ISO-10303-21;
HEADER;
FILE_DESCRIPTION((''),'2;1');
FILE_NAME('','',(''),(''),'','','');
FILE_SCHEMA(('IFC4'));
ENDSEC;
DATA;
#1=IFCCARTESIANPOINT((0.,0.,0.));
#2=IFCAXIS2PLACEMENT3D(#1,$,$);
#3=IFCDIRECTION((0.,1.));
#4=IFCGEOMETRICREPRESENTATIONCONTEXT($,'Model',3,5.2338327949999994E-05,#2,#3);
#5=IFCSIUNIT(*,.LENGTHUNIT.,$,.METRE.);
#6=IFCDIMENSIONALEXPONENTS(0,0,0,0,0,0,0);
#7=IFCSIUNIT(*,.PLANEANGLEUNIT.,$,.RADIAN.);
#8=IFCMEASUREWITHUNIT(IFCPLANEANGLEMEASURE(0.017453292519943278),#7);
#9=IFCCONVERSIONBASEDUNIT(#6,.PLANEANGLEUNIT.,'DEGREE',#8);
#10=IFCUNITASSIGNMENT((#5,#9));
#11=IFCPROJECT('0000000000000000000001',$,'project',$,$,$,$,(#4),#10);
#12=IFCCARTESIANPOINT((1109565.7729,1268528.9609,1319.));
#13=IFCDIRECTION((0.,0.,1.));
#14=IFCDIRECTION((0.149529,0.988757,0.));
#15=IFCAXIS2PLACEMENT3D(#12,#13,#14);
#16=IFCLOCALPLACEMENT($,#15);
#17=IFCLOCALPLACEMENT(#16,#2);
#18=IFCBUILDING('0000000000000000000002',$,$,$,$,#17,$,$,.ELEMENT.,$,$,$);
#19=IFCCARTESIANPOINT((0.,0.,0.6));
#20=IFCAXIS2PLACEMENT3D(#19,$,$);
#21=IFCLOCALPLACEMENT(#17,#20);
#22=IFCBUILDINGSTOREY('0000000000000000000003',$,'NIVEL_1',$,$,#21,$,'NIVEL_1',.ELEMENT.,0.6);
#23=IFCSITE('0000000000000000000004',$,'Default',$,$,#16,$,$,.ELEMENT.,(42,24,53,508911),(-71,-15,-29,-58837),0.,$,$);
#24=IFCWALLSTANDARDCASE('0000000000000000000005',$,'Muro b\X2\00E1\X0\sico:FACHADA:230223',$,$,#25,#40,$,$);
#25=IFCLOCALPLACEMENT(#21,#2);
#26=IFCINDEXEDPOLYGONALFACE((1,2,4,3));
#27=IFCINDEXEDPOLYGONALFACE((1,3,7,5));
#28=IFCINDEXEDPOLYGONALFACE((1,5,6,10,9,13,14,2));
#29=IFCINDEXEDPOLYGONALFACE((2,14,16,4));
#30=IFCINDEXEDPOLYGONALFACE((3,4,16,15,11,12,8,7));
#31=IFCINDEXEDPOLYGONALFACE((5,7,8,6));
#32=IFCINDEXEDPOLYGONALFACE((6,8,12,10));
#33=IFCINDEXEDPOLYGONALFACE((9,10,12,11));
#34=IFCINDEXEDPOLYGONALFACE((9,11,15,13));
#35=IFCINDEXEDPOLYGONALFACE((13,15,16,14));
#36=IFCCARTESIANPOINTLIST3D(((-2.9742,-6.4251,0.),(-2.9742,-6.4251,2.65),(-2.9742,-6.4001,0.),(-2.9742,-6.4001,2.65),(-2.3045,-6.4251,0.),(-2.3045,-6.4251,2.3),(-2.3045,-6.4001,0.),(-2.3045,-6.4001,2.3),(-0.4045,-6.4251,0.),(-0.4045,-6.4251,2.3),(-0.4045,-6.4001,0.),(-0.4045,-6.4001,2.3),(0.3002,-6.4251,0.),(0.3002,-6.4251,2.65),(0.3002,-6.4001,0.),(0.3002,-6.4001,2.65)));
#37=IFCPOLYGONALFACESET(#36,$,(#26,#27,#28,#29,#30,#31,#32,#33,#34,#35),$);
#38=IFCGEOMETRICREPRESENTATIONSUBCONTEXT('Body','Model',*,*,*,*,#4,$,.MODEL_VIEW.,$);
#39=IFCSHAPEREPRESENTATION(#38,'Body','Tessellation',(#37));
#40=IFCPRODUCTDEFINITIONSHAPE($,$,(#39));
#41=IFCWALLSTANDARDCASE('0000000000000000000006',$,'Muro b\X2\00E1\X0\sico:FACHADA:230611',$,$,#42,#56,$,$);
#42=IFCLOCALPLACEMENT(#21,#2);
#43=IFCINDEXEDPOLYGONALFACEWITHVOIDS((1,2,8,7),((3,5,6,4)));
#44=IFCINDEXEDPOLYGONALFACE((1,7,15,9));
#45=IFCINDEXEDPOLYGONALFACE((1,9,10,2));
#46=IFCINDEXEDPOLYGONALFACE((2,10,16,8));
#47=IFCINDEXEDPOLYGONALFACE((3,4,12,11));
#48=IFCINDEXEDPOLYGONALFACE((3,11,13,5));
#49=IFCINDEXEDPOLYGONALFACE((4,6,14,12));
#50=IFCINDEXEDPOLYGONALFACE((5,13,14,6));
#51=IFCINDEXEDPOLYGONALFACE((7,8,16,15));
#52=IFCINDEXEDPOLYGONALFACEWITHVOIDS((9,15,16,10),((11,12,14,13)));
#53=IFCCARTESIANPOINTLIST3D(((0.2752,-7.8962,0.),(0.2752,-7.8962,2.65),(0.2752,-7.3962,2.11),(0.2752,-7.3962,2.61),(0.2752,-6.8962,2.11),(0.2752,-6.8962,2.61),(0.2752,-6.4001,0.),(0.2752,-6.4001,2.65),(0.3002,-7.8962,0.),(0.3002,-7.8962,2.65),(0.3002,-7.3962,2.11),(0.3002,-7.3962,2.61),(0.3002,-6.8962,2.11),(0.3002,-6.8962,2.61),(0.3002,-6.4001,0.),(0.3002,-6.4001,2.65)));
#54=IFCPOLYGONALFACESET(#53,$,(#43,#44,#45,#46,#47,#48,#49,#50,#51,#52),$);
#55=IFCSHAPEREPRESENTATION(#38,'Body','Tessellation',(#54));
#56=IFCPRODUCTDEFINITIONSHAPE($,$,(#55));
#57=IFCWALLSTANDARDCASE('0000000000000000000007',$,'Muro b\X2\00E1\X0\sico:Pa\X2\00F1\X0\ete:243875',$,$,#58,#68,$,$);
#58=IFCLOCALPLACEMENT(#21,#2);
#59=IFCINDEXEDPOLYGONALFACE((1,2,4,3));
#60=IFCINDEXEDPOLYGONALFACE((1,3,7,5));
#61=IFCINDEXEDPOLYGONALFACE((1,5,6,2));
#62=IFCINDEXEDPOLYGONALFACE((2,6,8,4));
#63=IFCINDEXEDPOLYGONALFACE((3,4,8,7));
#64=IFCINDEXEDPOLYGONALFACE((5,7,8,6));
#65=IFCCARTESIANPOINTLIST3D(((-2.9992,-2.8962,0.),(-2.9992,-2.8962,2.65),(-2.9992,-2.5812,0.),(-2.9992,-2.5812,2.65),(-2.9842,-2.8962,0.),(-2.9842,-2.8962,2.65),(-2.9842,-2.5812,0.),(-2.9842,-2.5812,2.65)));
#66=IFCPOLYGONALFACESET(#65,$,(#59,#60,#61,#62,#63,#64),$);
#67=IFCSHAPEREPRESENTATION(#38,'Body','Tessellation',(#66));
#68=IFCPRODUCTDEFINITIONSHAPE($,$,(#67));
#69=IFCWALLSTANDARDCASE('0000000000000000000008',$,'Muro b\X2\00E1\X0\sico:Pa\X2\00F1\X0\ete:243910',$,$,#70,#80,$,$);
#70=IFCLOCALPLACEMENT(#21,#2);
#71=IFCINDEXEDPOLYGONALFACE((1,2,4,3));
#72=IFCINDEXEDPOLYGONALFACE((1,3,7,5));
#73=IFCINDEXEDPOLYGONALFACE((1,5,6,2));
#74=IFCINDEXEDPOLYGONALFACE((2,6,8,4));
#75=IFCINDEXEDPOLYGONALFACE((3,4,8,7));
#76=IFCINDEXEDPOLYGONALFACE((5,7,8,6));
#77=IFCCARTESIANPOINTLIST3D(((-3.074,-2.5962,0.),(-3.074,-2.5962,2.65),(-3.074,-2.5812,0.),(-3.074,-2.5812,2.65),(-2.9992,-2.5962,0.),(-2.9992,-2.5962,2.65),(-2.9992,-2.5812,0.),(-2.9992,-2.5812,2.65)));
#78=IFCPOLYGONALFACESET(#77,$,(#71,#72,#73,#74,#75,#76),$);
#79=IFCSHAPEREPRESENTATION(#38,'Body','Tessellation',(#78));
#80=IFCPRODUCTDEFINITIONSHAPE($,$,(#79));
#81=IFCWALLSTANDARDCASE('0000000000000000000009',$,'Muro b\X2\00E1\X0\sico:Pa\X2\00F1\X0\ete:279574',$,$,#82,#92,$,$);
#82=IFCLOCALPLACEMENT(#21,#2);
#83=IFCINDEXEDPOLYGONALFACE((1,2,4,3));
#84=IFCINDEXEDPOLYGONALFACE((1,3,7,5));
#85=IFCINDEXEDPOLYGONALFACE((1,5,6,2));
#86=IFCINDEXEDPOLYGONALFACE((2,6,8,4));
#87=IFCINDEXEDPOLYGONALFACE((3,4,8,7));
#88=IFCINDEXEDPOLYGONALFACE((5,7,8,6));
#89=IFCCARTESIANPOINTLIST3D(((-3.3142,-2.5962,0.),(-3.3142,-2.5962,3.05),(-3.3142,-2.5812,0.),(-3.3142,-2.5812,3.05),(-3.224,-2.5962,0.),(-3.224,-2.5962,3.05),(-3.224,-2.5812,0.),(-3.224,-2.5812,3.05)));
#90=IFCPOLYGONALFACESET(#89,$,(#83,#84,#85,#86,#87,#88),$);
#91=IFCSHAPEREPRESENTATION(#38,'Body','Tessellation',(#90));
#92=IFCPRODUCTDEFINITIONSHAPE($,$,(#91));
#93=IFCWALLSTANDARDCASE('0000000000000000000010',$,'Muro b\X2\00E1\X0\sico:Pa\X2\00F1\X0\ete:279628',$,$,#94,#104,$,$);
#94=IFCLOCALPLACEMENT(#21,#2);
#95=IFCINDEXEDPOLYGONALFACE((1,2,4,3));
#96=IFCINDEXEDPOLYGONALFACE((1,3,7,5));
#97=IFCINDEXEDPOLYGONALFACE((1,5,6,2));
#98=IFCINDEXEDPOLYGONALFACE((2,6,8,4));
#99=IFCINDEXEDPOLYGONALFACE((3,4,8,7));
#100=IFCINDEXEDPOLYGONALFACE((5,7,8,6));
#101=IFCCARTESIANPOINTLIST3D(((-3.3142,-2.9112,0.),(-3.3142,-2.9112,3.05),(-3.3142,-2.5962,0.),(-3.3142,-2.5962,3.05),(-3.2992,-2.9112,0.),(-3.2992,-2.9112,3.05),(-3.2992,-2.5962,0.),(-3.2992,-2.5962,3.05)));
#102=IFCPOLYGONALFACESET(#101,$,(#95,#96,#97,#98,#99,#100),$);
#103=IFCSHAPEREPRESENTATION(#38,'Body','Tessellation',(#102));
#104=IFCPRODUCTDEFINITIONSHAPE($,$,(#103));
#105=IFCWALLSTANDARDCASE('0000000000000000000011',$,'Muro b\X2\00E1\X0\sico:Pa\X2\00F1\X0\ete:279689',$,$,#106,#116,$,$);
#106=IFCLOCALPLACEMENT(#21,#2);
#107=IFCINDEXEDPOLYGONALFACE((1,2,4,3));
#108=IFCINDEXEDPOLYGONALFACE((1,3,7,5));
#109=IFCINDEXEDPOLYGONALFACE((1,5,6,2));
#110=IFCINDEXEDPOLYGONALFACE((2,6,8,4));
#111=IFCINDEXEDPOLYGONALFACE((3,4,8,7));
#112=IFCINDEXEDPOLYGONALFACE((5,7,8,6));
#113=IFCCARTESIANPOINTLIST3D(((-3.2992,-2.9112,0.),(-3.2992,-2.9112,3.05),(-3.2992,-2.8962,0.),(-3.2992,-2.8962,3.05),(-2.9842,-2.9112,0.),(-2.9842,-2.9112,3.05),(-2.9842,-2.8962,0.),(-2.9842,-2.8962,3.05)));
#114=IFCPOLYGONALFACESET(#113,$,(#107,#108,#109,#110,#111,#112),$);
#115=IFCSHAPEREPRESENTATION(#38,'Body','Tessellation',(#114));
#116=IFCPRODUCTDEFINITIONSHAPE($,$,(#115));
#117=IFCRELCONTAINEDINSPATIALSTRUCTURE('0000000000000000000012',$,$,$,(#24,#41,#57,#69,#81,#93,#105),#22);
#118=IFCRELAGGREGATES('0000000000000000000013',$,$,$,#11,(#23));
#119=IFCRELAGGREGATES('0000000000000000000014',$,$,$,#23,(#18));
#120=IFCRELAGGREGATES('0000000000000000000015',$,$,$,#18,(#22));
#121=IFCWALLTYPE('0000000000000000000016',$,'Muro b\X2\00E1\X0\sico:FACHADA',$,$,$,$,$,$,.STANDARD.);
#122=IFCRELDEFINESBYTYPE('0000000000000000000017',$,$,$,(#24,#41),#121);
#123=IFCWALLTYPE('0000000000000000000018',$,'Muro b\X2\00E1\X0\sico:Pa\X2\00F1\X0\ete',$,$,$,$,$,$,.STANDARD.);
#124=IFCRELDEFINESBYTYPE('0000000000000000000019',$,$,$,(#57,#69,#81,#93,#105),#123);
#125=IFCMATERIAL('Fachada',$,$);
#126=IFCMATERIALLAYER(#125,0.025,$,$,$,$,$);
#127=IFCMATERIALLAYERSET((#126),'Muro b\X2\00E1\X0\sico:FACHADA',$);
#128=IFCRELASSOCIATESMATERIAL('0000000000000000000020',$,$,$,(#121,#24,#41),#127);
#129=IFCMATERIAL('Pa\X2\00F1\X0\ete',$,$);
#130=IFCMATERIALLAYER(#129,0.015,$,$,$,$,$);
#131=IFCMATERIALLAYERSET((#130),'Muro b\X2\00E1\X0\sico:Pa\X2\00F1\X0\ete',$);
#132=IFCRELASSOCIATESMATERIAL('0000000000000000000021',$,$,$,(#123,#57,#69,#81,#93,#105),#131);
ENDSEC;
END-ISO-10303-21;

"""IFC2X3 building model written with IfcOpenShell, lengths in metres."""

from ifc_helpers import new_model, entity, si_unit, converted_unit, direction, frame, frame_2d, origin, place, context, subcontext, project, spatial, rectangle, extrude, material, layer, layer_set, layer_usage, type_object, element, save


model = new_model("IFC2X3")

# Units and contexts
model_context = context("Model", 3, precision=5.2338327949999994e-05, world=origin(), true_north=direction((0.0, 1.0)))
body_context = subcontext(model_context, "Body", "Model", "MODEL_VIEW")
ifc_project = project(units=[si_unit("LENGTHUNIT", "METRE"), converted_unit("PLANEANGLEUNIT", "DEGREE", entity("IfcPlaneAngleMeasure", 0.017453292519943278), si_unit("PLANEANGLEUNIT", "RADIAN"), dimensions=[0, 0, 0, 0, 0, 0, 0])], contexts=[model_context])

# Site, building, storey
site_placement = place(None, frame((1109565.7729, 1268528.9609, 1319.0), z_axis=(0.0, 0.0, 1.0), x_axis=(0.149529, 0.988757, 0.0)))
site = spatial("IfcSite", under=ifc_project, at=site_placement, Name="Default", CompositionType="ELEMENT", RefLatitude=(42, 24, 53, 508911), RefLongitude=(-71, -15, -29, -58837), RefElevation=0.0)
building_placement = place(site_placement, origin())
building = spatial("IfcBuilding", under=site, at=building_placement, CompositionType="ELEMENT")
storey_placement = place(building_placement, frame((0.0, 0.0, 0.6)))
storey = spatial("IfcBuildingStorey", under=building, at=storey_placement, Name="NIVEL_1", LongName="NIVEL_1", CompositionType="ELEMENT", Elevation=0.6)

# Shared definitions
ifc_material_1 = material(Name="Pañete")

# Walls, openings
ifc_material_2 = material(Name="Fachada")
ifc_layer_1 = layer(ifc_material_2, 0.025)
ifc_layer_set_1 = layer_set([ifc_layer_1], Name="Muro básico:FACHADA")
ifc_layer_usage_1 = layer_usage(ifc_layer_set_1, "AXIS2", "POSITIVE", -0.0125)
wall_type_1 = type_object("IfcWallType", Name="Muro básico:FACHADA", PredefinedType="STANDARD", material=ifc_layer_set_1)
wall_1_placement = place(storey_placement, frame((-2.9742, -6.4126, 0.0)))
wall_1 = element("IfcWallStandardCase", 1, at=wall_1_placement, inside=storey, type_object=wall_type_1, material=ifc_layer_usage_1, Name="Muro básico:FACHADA:230223", context=body_context, shape_type="SweptSolid", body=[
    extrude(rectangle(XDim=3.2744, YDim=0.025, at=frame_2d((1.6372, 0.0), x_axis=(-1.0, 0.0))), origin(), (0.0, 0.0, 1.0), 2.65),
])
opening_1_placement = place(wall_1_placement, origin())
element("IfcOpeningElement", 2, at=opening_1_placement, cuts=wall_1, ObjectType="Opening", context=body_context, shape_type="SweptSolid", body=[
    extrude(rectangle(XDim=2.3, YDim=1.9, at=frame_2d((0.0, 0.0), x_axis=(0.0, 1.0))), frame((1.6197, 0.0125, 1.15), z_axis=(0.0, -1.0, 0.0), x_axis=(1.0, 0.0, 0.0)), (0.0, 0.0, 1.0), 0.025),
])
ifc_layer_usage_2 = layer_usage(ifc_layer_set_1, "AXIS2", "POSITIVE", -0.0125)
wall_2_placement = place(storey_placement, frame((0.2877, -6.4001, 0.0), z_axis=(0.0, 0.0, 1.0), x_axis=(0.0, -1.0, 0.0)))
wall_2 = element("IfcWallStandardCase", 3, at=wall_2_placement, inside=storey, type_object=wall_type_1, material=ifc_layer_usage_2, Name="Muro básico:FACHADA:230611", context=body_context, shape_type="SweptSolid", body=[
    extrude(rectangle(XDim=1.4961, YDim=0.025, at=frame_2d((0.748, 0.0), x_axis=(-1.0, 0.0))), origin(), (0.0, 0.0, 1.0), 2.65),
])
opening_2_placement = place(wall_2_placement, origin())
element("IfcOpeningElement", 4, at=opening_2_placement, cuts=wall_2, ObjectType="Opening", context=body_context, shape_type="SweptSolid", body=[
    extrude(rectangle(XDim=0.5, YDim=0.5, at=frame_2d((0.0, 0.0), x_axis=(0.0, 1.0))), frame((0.7461, 0.0125, 2.36), z_axis=(0.0, -1.0, 0.0), x_axis=(-1.0, 0.0, 0.0)), (0.0, 0.0, 1.0), 0.025),
])

# Walls
ifc_layer_2 = layer(ifc_material_1, 0.015)
ifc_layer_set_2 = layer_set([ifc_layer_2], Name="Muro básico:Pañete")
ifc_layer_usage_3 = layer_usage(ifc_layer_set_2, "AXIS2", "POSITIVE", -0.0075)
wall_type_2 = type_object("IfcWallType", Name="Muro básico:Pañete", PredefinedType="STANDARD", material=ifc_layer_set_2)
wall_3_placement = place(storey_placement, frame((-2.9917, -2.8962, 0.0), z_axis=(0.0, 0.0, 1.0), x_axis=(0.0, 1.0, 0.0)))
element("IfcWallStandardCase", 5, at=wall_3_placement, inside=storey, type_object=wall_type_2, material=ifc_layer_usage_3, Name="Muro básico:Pañete:243875", context=body_context, shape_type="SweptSolid", body=[
    extrude(rectangle(XDim=0.315, YDim=0.015, at=frame_2d((0.1575, 0.0), x_axis=(-1.0, 0.0))), origin(), (0.0, 0.0, 1.0), 2.65),
])
ifc_layer_usage_4 = layer_usage(ifc_layer_set_2, "AXIS2", "POSITIVE", -0.0075)
wall_4_placement = place(storey_placement, frame((-2.9992, -2.5887, 0.0), z_axis=(0.0, 0.0, 1.0), x_axis=(-1.0, 0.0, 0.0)))
element("IfcWallStandardCase", 6, at=wall_4_placement, inside=storey, type_object=wall_type_2, material=ifc_layer_usage_4, Name="Muro básico:Pañete:243910", context=body_context, shape_type="SweptSolid", body=[
    extrude(rectangle(XDim=0.0748, YDim=0.015, at=frame_2d((0.0374, 0.0), x_axis=(-1.0, 0.0))), origin(), (0.0, 0.0, 1.0), 2.65),
])
ifc_layer_usage_5 = layer_usage(ifc_layer_set_2, "AXIS2", "POSITIVE", -0.0075)
wall_5_placement = place(storey_placement, frame((-3.224, -2.5887, 0.0), z_axis=(0.0, 0.0, 1.0), x_axis=(-1.0, 0.0, 0.0)))
element("IfcWallStandardCase", 7, at=wall_5_placement, inside=storey, type_object=wall_type_2, material=ifc_layer_usage_5, Name="Muro básico:Pañete:279574", context=body_context, shape_type="SweptSolid", body=[
    extrude(rectangle(XDim=0.0902, YDim=0.015, at=frame_2d((0.0451, 0.0), x_axis=(-1.0, 0.0))), origin(), (0.0, 0.0, 1.0), 3.05),
])
ifc_layer_usage_6 = layer_usage(ifc_layer_set_2, "AXIS2", "POSITIVE", -0.0075)
wall_6_placement = place(storey_placement, frame((-3.3067, -2.5962, 0.0), z_axis=(0.0, 0.0, 1.0), x_axis=(0.0, -1.0, 0.0)))
element("IfcWallStandardCase", 8, at=wall_6_placement, inside=storey, type_object=wall_type_2, material=ifc_layer_usage_6, Name="Muro básico:Pañete:279628", context=body_context, shape_type="SweptSolid", body=[
    extrude(rectangle(XDim=0.315, YDim=0.015, at=frame_2d((0.1575, 0.0), x_axis=(-1.0, 0.0))), origin(), (0.0, 0.0, 1.0), 3.05),
])
ifc_layer_usage_7 = layer_usage(ifc_layer_set_2, "AXIS2", "POSITIVE", -0.0075)
wall_7_placement = place(storey_placement, frame((-3.2992, -2.9037, 0.0)))
element("IfcWallStandardCase", 9, at=wall_7_placement, inside=storey, type_object=wall_type_2, material=ifc_layer_usage_7, Name="Muro básico:Pañete:279689", context=body_context, shape_type="SweptSolid", body=[
    extrude(rectangle(XDim=0.315, YDim=0.015, at=frame_2d((0.1575, 0.0), x_axis=(-1.0, 0.0))), origin(), (0.0, 0.0, 1.0), 3.05),
])

save(model, "model.ifc")
